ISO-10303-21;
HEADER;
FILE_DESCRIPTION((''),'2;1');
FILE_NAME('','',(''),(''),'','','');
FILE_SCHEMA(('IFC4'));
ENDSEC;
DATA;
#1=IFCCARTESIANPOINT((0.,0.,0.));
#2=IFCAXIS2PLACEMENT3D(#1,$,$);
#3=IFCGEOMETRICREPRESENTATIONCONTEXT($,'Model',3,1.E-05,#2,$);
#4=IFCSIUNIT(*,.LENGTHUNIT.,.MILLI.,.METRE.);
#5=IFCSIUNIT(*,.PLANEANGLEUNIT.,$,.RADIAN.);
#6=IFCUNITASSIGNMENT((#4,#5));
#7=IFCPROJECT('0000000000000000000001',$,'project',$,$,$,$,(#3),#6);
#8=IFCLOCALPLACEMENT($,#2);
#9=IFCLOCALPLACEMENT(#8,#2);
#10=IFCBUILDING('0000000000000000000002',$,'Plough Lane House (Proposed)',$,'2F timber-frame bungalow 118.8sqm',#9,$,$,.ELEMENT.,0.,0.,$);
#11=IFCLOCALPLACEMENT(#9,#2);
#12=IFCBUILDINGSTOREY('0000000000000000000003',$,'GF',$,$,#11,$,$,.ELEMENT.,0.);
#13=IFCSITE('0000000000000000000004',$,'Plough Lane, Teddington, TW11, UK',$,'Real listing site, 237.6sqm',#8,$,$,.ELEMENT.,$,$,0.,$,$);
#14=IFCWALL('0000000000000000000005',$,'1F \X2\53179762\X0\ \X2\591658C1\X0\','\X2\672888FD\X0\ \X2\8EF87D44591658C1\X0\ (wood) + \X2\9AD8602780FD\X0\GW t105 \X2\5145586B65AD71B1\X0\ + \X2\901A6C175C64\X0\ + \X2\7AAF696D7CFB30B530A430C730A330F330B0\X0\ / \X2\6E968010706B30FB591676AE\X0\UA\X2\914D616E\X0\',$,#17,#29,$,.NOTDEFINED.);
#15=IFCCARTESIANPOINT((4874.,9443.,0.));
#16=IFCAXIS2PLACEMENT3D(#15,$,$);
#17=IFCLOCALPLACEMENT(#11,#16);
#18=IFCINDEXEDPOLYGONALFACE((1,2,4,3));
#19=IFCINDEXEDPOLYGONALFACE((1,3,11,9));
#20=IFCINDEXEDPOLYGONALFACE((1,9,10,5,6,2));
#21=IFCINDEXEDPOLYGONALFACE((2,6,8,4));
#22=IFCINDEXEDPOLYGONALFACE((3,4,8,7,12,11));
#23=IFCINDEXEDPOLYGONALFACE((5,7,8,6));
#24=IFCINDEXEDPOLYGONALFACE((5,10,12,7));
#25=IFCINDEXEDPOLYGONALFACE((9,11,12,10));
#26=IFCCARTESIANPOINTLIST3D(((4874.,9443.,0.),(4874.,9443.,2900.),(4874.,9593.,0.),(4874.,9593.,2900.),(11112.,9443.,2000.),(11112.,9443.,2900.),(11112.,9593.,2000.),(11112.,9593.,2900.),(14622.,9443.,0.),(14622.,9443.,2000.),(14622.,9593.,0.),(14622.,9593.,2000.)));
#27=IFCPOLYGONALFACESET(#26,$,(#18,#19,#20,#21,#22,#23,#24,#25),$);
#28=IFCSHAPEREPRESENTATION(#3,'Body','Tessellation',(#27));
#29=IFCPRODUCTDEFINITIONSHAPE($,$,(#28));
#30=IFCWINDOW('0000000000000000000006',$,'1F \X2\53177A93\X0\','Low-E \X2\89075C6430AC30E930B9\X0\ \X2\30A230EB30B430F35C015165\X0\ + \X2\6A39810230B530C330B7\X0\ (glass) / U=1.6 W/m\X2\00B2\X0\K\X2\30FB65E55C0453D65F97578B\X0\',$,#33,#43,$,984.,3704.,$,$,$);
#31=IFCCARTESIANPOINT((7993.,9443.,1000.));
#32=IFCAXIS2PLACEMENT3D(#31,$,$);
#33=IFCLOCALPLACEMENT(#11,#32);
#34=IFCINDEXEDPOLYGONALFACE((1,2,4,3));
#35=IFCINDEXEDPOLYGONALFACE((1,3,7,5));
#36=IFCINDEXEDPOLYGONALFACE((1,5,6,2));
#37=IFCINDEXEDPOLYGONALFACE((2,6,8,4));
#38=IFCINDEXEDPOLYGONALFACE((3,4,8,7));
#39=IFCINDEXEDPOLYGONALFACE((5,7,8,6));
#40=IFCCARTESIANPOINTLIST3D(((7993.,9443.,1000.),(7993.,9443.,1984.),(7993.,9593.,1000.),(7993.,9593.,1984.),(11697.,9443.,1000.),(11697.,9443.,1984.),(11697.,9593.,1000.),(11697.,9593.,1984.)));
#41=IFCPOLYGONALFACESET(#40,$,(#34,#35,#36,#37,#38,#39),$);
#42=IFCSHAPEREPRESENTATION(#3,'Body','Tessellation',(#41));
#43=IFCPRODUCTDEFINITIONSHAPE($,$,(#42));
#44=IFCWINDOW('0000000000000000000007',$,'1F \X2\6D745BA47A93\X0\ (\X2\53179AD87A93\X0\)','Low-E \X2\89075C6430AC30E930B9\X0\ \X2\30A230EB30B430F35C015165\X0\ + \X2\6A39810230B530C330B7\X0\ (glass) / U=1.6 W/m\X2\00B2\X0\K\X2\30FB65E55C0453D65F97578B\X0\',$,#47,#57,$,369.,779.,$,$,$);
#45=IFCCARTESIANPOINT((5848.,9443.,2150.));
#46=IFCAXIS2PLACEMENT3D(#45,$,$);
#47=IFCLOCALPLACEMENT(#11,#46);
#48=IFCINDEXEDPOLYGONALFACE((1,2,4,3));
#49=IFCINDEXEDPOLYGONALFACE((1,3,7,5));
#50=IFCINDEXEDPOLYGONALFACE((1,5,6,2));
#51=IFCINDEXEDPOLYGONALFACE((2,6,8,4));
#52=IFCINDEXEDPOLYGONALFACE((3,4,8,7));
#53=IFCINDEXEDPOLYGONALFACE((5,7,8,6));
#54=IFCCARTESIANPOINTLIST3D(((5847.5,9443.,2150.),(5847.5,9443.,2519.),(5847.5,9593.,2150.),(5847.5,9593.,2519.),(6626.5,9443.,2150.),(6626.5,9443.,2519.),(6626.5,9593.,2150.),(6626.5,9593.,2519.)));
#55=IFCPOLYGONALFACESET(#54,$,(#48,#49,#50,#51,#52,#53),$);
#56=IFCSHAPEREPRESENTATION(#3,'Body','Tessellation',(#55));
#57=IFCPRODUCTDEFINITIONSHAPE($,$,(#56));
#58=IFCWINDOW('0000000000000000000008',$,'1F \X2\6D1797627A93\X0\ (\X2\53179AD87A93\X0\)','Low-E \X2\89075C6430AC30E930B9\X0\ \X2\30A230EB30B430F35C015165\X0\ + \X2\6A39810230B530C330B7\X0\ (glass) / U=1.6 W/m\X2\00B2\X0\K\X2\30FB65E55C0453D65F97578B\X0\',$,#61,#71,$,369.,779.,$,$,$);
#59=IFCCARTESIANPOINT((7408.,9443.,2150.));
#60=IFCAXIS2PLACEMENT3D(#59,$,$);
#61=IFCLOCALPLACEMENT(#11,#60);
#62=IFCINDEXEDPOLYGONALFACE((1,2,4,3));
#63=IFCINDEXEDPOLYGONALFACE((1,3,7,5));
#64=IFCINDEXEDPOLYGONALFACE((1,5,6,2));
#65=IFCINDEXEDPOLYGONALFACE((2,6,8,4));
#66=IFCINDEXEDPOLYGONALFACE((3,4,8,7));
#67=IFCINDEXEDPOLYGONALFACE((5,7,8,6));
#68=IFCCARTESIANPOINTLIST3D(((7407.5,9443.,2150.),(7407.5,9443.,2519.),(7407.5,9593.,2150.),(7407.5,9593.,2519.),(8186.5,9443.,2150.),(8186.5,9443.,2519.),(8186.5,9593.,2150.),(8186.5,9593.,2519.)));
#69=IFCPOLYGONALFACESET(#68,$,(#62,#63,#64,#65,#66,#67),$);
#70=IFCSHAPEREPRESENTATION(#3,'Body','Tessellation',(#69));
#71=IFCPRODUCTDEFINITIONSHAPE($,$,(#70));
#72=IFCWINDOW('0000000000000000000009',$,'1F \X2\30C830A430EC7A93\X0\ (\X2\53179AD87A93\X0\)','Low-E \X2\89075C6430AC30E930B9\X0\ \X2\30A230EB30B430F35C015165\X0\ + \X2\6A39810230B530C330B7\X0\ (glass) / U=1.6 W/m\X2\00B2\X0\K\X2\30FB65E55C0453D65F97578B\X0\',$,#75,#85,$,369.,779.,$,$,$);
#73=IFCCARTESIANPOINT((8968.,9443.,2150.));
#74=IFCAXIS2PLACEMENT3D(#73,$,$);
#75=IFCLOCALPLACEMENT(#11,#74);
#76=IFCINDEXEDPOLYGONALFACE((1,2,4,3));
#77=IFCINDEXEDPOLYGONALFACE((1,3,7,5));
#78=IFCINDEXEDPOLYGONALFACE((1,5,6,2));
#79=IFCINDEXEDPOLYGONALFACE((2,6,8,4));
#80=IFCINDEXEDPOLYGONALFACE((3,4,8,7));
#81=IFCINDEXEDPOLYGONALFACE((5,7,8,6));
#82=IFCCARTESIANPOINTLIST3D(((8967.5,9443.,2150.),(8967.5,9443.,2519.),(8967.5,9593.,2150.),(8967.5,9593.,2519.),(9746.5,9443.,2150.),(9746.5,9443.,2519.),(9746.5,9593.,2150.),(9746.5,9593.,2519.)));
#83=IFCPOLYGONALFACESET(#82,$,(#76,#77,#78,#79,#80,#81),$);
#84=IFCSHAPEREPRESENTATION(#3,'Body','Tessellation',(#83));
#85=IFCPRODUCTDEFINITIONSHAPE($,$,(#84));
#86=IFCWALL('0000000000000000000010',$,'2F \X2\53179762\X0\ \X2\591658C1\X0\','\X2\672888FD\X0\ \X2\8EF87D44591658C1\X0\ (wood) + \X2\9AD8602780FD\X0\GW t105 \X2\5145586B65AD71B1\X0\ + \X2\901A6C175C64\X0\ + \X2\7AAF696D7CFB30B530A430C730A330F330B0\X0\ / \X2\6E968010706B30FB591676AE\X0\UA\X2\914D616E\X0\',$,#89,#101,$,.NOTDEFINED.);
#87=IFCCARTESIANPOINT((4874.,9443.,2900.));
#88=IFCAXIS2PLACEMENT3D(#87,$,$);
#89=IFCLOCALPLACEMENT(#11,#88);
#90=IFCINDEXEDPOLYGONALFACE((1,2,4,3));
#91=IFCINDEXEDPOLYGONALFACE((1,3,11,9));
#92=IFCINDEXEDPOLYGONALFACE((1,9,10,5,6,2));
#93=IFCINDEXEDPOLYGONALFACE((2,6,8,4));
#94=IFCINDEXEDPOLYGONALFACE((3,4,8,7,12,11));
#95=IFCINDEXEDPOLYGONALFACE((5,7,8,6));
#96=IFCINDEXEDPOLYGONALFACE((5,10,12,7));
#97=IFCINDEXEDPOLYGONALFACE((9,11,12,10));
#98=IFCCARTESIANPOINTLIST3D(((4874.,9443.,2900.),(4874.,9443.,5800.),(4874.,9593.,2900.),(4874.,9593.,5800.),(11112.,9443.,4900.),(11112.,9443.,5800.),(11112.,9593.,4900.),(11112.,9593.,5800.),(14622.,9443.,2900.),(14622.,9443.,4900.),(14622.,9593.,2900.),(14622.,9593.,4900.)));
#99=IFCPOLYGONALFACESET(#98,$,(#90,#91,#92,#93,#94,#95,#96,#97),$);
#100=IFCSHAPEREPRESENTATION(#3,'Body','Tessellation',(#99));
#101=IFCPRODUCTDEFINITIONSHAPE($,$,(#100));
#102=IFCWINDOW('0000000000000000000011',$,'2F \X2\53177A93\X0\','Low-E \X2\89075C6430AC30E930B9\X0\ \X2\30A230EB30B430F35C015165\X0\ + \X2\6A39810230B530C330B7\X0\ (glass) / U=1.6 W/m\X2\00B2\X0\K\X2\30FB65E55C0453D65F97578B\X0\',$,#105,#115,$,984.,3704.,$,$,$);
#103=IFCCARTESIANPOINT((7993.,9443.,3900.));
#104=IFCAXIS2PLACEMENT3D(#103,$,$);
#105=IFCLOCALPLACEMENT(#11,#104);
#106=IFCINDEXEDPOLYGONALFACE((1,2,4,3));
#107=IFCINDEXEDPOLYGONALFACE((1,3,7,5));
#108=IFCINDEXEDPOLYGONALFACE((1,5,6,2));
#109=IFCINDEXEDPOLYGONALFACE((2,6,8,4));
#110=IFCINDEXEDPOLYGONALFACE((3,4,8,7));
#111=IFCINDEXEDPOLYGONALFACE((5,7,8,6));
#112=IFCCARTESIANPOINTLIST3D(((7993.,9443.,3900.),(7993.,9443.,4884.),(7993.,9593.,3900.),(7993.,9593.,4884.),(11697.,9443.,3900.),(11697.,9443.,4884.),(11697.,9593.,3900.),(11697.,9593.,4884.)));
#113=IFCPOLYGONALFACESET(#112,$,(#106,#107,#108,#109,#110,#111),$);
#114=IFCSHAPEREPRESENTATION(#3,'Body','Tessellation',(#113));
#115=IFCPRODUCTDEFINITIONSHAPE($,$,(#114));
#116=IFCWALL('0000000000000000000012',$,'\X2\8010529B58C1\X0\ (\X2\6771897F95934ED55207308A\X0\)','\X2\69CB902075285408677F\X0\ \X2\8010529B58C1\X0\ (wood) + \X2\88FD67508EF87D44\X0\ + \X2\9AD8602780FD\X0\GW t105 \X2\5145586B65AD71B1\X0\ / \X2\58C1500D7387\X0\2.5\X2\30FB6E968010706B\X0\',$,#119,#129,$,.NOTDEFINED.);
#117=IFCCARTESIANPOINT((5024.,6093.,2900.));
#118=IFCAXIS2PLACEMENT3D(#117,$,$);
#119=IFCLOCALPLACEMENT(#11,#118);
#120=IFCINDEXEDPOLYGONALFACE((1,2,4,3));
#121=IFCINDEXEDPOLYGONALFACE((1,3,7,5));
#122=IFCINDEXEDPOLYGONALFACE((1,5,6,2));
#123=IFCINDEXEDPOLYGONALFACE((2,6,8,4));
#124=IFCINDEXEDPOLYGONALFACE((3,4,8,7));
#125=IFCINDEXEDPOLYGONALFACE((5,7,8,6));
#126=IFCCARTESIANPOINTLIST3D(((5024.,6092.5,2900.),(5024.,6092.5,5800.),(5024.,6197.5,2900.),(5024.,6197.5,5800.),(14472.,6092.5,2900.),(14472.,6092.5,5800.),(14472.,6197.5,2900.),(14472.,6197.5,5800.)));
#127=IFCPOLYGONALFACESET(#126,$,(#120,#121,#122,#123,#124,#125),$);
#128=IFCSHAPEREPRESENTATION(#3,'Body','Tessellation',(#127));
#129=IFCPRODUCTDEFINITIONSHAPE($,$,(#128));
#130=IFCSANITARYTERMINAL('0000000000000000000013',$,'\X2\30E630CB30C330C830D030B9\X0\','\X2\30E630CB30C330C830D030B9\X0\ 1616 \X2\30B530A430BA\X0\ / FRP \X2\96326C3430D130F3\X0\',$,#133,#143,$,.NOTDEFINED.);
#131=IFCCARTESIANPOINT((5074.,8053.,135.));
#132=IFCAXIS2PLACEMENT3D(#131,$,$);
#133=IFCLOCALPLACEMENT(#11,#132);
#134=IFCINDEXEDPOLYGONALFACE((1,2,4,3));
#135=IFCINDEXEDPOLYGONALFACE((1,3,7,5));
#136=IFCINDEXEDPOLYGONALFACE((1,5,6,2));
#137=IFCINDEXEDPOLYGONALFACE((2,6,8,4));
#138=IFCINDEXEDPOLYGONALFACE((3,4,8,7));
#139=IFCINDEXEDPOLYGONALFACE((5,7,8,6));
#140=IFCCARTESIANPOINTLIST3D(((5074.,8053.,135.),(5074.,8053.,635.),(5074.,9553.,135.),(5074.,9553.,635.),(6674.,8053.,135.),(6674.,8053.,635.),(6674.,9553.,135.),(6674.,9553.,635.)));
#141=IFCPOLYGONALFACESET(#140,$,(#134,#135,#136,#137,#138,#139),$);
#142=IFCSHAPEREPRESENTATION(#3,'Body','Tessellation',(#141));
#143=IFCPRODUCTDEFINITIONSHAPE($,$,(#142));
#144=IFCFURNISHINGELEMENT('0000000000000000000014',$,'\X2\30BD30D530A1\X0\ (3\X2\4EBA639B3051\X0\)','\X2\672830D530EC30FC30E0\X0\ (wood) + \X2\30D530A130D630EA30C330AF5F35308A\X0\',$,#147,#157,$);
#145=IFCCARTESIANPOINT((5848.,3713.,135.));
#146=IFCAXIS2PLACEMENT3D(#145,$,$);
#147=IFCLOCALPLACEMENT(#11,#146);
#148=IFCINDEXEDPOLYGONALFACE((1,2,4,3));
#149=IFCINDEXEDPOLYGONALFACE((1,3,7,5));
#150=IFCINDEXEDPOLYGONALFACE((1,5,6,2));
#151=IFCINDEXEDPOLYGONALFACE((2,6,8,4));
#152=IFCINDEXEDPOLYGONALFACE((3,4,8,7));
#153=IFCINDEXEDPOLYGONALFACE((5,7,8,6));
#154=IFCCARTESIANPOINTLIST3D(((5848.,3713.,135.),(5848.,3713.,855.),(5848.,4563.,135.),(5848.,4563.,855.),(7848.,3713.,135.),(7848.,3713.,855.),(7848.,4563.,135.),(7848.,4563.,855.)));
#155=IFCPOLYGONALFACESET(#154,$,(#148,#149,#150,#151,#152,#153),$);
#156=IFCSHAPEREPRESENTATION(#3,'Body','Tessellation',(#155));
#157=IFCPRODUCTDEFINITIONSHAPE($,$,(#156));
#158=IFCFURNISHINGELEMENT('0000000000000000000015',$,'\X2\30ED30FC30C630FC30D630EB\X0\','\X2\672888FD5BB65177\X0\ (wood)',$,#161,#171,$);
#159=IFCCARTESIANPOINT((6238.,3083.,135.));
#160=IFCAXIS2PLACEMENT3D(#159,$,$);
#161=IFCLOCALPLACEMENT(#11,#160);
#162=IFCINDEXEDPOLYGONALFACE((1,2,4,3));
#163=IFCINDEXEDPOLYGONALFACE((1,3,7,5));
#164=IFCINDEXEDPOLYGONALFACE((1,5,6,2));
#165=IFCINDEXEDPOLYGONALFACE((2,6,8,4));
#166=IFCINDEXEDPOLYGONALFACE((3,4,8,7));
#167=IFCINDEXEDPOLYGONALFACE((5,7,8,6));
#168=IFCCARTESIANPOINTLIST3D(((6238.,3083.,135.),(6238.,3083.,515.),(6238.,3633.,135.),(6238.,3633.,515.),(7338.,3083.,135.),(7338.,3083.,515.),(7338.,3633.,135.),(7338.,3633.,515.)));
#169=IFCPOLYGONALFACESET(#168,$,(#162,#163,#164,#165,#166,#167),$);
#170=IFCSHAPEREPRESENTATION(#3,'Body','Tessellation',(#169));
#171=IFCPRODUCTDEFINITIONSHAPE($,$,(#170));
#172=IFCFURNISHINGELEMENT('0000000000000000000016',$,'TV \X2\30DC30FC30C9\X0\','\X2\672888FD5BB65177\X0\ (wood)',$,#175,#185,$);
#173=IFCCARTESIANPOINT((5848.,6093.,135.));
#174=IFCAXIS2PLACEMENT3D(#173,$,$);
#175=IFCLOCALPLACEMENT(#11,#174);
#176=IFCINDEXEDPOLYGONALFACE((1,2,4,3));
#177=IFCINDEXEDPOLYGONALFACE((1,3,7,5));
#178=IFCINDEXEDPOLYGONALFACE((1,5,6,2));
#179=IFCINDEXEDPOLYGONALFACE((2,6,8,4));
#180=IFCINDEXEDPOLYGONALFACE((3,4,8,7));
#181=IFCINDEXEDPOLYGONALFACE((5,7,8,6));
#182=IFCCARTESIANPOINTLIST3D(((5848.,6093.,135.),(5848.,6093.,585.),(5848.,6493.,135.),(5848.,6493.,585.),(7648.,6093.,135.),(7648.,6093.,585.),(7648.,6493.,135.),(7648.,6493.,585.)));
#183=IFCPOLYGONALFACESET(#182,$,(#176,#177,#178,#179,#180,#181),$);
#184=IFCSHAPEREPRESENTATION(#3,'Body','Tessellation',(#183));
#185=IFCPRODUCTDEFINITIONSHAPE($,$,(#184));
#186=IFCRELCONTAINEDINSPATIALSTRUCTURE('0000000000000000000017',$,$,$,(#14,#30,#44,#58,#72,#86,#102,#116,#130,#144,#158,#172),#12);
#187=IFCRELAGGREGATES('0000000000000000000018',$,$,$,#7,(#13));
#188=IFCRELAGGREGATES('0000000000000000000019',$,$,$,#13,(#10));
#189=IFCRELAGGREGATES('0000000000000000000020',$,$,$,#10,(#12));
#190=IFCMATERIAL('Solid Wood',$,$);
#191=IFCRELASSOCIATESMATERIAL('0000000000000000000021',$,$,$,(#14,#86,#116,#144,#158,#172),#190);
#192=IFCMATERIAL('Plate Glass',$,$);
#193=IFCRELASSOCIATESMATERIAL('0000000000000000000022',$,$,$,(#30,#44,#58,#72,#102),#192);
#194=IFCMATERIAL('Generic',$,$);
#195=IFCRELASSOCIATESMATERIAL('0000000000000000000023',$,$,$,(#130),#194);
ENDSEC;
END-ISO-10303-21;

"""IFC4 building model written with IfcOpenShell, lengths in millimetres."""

from ifc_helpers import new_model, si_unit, frame, frame_2d, origin, place, context, project, spatial, rectangle, extrude, material, element, fill, save


model = new_model("IFC4")

# Units and contexts
model_context = context("Model", 3, precision=1e-05, world=origin())
ifc_project = project(units=[si_unit("LENGTHUNIT", "METRE", prefix="MILLI"), si_unit("PLANEANGLEUNIT", "RADIAN")], contexts=[model_context])

# Site, building, storey
site_placement = place(None, origin())
site = spatial("IfcSite", under=ifc_project, at=site_placement, Name="Plough Lane, Teddington, TW11, UK", ObjectType="Real listing site, 237.6sqm", CompositionType="ELEMENT", RefElevation=0.0)
building_placement = place(site_placement, origin())
building = spatial("IfcBuilding", under=site, at=building_placement, Name="Plough Lane House (Proposed)", ObjectType="2F timber-frame bungalow 118.8sqm", CompositionType="ELEMENT", ElevationOfRefHeight=0.0, ElevationOfTerrain=0.0)
storey_placement = place(building_placement, origin())
storey = spatial("IfcBuildingStorey", under=building, at=storey_placement, Name="GF", CompositionType="ELEMENT", Elevation=0.0)

# Wall, openings, windows
ifc_material_1 = material(Name="Solid Wood")
wall_1_placement = place(storey_placement, frame((4874.0, 9443.0, 0.0)))
wall_1 = element("IfcWall", 1, at=wall_1_placement, inside=storey, material=ifc_material_1, Name="1F 北面 外壁", Description="木製 軸組外壁 (wood) + 高性能GW t105 充填断熱 + 通気層 + 窯業系サイディング / 準耐火・外皮UA配慮", PredefinedType="NOTDEFINED", context=model_context, shape_type="SweptSolid", body=[
    extrude(rectangle(XDim=9748.0, YDim=150.0, at=frame_2d((4874.0, 75.0))), frame((4874.0, 9443.0, 0.0)), (0.0, 0.0, 1.0), 2900.0),
])
opening_1_placement = place(storey_placement, frame((7993.0, 9443.0, 1000.0)))
opening_1 = element("IfcOpeningElement", 2, at=opening_1_placement, cuts=wall_1, PredefinedType="NOTDEFINED", context=model_context, shape_type="SweptSolid", body=[
    extrude(rectangle(XDim=3704.0, YDim=150.0, at=frame_2d((1852.0, 75.0))), frame((7993.0, 9443.0, 1000.0)), (0.0, 0.0, 1.0), 984.0),
])
opening_2_placement = place(storey_placement, frame((5848.0, 9443.0, 2150.0)))
opening_2 = element("IfcOpeningElement", 3, at=opening_2_placement, cuts=wall_1, PredefinedType="NOTDEFINED", context=model_context, shape_type="SweptSolid", body=[
    extrude(rectangle(XDim=779.0, YDim=150.0, at=frame_2d((389.0, 75.0))), frame((5848.0, 9443.0, 2150.0)), (0.0, 0.0, 1.0), 369.0),
])
opening_3_placement = place(storey_placement, frame((7408.0, 9443.0, 2150.0)))
opening_3 = element("IfcOpeningElement", 4, at=opening_3_placement, cuts=wall_1, PredefinedType="NOTDEFINED", context=model_context, shape_type="SweptSolid", body=[
    extrude(rectangle(XDim=779.0, YDim=150.0, at=frame_2d((389.0, 75.0))), frame((7408.0, 9443.0, 2150.0)), (0.0, 0.0, 1.0), 369.0),
])
opening_4_placement = place(storey_placement, frame((8968.0, 9443.0, 2150.0)))
opening_4 = element("IfcOpeningElement", 5, at=opening_4_placement, cuts=wall_1, PredefinedType="NOTDEFINED", context=model_context, shape_type="SweptSolid", body=[
    extrude(rectangle(XDim=779.0, YDim=150.0, at=frame_2d((389.0, 75.0))), frame((8968.0, 9443.0, 2150.0)), (0.0, 0.0, 1.0), 369.0),
])
ifc_material_2 = material(Name="Plate Glass")
window_1_placement = place(storey_placement, frame((7993.0, 9443.0, 1000.0)))
window_1 = element("IfcWindow", 6, at=window_1_placement, inside=storey, material=ifc_material_2, Name="1F 北窓", Description="Low-E 複層ガラス アルゴン封入 + 樹脂サッシ (glass) / U=1.6 W/m²K・日射取得型", OverallHeight=984.0, OverallWidth=3704.0, context=model_context, shape_type="SweptSolid", body=[
    extrude(rectangle(XDim=3704.0, YDim=150.0, at=frame_2d((1852.0, 75.0))), frame((7993.0, 9443.0, 1000.0)), (0.0, 0.0, 1.0), 984.0),
])
fill(opening_1, window_1)
window_2_placement = place(storey_placement, frame((5848.0, 9443.0, 2150.0)))
window_2 = element("IfcWindow", 7, at=window_2_placement, inside=storey, material=ifc_material_2, Name="1F 浴室窓 (北高窓)", Description="Low-E 複層ガラス アルゴン封入 + 樹脂サッシ (glass) / U=1.6 W/m²K・日射取得型", OverallHeight=369.0, OverallWidth=779.0, context=model_context, shape_type="SweptSolid", body=[
    extrude(rectangle(XDim=779.0, YDim=150.0, at=frame_2d((389.0, 75.0))), frame((5848.0, 9443.0, 2150.0)), (0.0, 0.0, 1.0), 369.0),
])
fill(opening_2, window_2)
window_3_placement = place(storey_placement, frame((7408.0, 9443.0, 2150.0)))
window_3 = element("IfcWindow", 8, at=window_3_placement, inside=storey, material=ifc_material_2, Name="1F 洗面窓 (北高窓)", Description="Low-E 複層ガラス アルゴン封入 + 樹脂サッシ (glass) / U=1.6 W/m²K・日射取得型", OverallHeight=369.0, OverallWidth=779.0, context=model_context, shape_type="SweptSolid", body=[
    extrude(rectangle(XDim=779.0, YDim=150.0, at=frame_2d((389.0, 75.0))), frame((7408.0, 9443.0, 2150.0)), (0.0, 0.0, 1.0), 369.0),
])
fill(opening_3, window_3)
window_4_placement = place(storey_placement, frame((8968.0, 9443.0, 2150.0)))
window_4 = element("IfcWindow", 9, at=window_4_placement, inside=storey, material=ifc_material_2, Name="1F トイレ窓 (北高窓)", Description="Low-E 複層ガラス アルゴン封入 + 樹脂サッシ (glass) / U=1.6 W/m²K・日射取得型", OverallHeight=369.0, OverallWidth=779.0, context=model_context, shape_type="SweptSolid", body=[
    extrude(rectangle(XDim=779.0, YDim=150.0, at=frame_2d((389.0, 75.0))), frame((8968.0, 9443.0, 2150.0)), (0.0, 0.0, 1.0), 369.0),
])
fill(opening_4, window_4)

# Wall, opening, window
wall_2_placement = place(storey_placement, frame((4874.0, 9443.0, 2900.0)))
wall_2 = element("IfcWall", 10, at=wall_2_placement, inside=storey, material=ifc_material_1, Name="2F 北面 外壁", Description="木製 軸組外壁 (wood) + 高性能GW t105 充填断熱 + 通気層 + 窯業系サイディング / 準耐火・外皮UA配慮", PredefinedType="NOTDEFINED", context=model_context, shape_type="SweptSolid", body=[
    extrude(rectangle(XDim=9748.0, YDim=150.0, at=frame_2d((4874.0, 75.0))), frame((4874.0, 9443.0, 2900.0)), (0.0, 0.0, 1.0), 2900.0),
])
opening_5_placement = place(storey_placement, frame((7993.0, 9443.0, 3900.0)))
opening_5 = element("IfcOpeningElement", 11, at=opening_5_placement, cuts=wall_2, PredefinedType="NOTDEFINED", context=model_context, shape_type="SweptSolid", body=[
    extrude(rectangle(XDim=3704.0, YDim=150.0, at=frame_2d((1852.0, 75.0))), frame((7993.0, 9443.0, 3900.0)), (0.0, 0.0, 1.0), 984.0),
])
window_5_placement = place(storey_placement, frame((7993.0, 9443.0, 3900.0)))
window_5 = element("IfcWindow", 12, at=window_5_placement, inside=storey, material=ifc_material_2, Name="2F 北窓", Description="Low-E 複層ガラス アルゴン封入 + 樹脂サッシ (glass) / U=1.6 W/m²K・日射取得型", OverallHeight=984.0, OverallWidth=3704.0, context=model_context, shape_type="SweptSolid", body=[
    extrude(rectangle(XDim=3704.0, YDim=150.0, at=frame_2d((1852.0, 75.0))), frame((7993.0, 9443.0, 3900.0)), (0.0, 0.0, 1.0), 984.0),
])
fill(opening_5, window_5)

# Wall
wall_3_placement = place(storey_placement, frame((5024.0, 6093.0, 2900.0)))
element("IfcWall", 13, at=wall_3_placement, inside=storey, material=ifc_material_1, Name="耐力壁 (東西間仕切り)", Description="構造用合板 耐力壁 (wood) + 製材軸組 + 高性能GW t105 充填断熱 / 壁倍率2.5・準耐火", PredefinedType="NOTDEFINED", context=model_context, shape_type="SweptSolid", body=[
    extrude(rectangle(XDim=9448.0, YDim=105.0, at=frame_2d((4724.0, 52.0))), frame((5024.0, 6093.0, 2900.0)), (0.0, 0.0, 1.0), 2900.0),
])

# Sanitary terminal
ifc_material_3 = material(Name="Generic")
sanitary_terminal_placement = place(storey_placement, frame((5074.0, 8053.0, 135.0)))
element("IfcSanitaryTerminal", 14, at=sanitary_terminal_placement, inside=storey, material=ifc_material_3, Name="ユニットバス", Description="ユニットバス 1616 サイズ / FRP 防水パン", PredefinedType="NOTDEFINED", context=model_context, shape_type="SweptSolid", body=[
    extrude(rectangle(XDim=1600.0, YDim=1500.0, at=frame_2d((800.0, 750.0))), frame((5074.0, 8053.0, 135.0)), (0.0, 0.0, 1.0), 500.0),
])

# Furnishing elements
furnishing_1_placement = place(storey_placement, frame((5848.0, 3713.0, 135.0)))
element("IfcFurnishingElement", 15, at=furnishing_1_placement, inside=storey, material=ifc_material_1, Name="ソファ (3人掛け)", Description="木フレーム (wood) + ファブリック張り", context=model_context, shape_type="SweptSolid", body=[
    extrude(rectangle(XDim=2000.0, YDim=850.0, at=frame_2d((1000.0, 425.0))), frame((5848.0, 3713.0, 135.0)), (0.0, 0.0, 1.0), 720.0),
])
furnishing_2_placement = place(storey_placement, frame((6238.0, 3083.0, 135.0)))
element("IfcFurnishingElement", 16, at=furnishing_2_placement, inside=storey, material=ifc_material_1, Name="ローテーブル", Description="木製家具 (wood)", context=model_context, shape_type="SweptSolid", body=[
    extrude(rectangle(XDim=1100.0, YDim=550.0, at=frame_2d((550.0, 275.0))), frame((6238.0, 3083.0, 135.0)), (0.0, 0.0, 1.0), 380.0),
])
furnishing_3_placement = place(storey_placement, frame((5848.0, 6093.0, 135.0)))
element("IfcFurnishingElement", 17, at=furnishing_3_placement, inside=storey, material=ifc_material_1, Name="TV ボード", Description="木製家具 (wood)", context=model_context, shape_type="SweptSolid", body=[
    extrude(rectangle(XDim=1800.0, YDim=400.0, at=frame_2d((900.0, 200.0))), frame((5848.0, 6093.0, 135.0)), (0.0, 0.0, 1.0), 450.0),
])

save(model, "model.ifc")
